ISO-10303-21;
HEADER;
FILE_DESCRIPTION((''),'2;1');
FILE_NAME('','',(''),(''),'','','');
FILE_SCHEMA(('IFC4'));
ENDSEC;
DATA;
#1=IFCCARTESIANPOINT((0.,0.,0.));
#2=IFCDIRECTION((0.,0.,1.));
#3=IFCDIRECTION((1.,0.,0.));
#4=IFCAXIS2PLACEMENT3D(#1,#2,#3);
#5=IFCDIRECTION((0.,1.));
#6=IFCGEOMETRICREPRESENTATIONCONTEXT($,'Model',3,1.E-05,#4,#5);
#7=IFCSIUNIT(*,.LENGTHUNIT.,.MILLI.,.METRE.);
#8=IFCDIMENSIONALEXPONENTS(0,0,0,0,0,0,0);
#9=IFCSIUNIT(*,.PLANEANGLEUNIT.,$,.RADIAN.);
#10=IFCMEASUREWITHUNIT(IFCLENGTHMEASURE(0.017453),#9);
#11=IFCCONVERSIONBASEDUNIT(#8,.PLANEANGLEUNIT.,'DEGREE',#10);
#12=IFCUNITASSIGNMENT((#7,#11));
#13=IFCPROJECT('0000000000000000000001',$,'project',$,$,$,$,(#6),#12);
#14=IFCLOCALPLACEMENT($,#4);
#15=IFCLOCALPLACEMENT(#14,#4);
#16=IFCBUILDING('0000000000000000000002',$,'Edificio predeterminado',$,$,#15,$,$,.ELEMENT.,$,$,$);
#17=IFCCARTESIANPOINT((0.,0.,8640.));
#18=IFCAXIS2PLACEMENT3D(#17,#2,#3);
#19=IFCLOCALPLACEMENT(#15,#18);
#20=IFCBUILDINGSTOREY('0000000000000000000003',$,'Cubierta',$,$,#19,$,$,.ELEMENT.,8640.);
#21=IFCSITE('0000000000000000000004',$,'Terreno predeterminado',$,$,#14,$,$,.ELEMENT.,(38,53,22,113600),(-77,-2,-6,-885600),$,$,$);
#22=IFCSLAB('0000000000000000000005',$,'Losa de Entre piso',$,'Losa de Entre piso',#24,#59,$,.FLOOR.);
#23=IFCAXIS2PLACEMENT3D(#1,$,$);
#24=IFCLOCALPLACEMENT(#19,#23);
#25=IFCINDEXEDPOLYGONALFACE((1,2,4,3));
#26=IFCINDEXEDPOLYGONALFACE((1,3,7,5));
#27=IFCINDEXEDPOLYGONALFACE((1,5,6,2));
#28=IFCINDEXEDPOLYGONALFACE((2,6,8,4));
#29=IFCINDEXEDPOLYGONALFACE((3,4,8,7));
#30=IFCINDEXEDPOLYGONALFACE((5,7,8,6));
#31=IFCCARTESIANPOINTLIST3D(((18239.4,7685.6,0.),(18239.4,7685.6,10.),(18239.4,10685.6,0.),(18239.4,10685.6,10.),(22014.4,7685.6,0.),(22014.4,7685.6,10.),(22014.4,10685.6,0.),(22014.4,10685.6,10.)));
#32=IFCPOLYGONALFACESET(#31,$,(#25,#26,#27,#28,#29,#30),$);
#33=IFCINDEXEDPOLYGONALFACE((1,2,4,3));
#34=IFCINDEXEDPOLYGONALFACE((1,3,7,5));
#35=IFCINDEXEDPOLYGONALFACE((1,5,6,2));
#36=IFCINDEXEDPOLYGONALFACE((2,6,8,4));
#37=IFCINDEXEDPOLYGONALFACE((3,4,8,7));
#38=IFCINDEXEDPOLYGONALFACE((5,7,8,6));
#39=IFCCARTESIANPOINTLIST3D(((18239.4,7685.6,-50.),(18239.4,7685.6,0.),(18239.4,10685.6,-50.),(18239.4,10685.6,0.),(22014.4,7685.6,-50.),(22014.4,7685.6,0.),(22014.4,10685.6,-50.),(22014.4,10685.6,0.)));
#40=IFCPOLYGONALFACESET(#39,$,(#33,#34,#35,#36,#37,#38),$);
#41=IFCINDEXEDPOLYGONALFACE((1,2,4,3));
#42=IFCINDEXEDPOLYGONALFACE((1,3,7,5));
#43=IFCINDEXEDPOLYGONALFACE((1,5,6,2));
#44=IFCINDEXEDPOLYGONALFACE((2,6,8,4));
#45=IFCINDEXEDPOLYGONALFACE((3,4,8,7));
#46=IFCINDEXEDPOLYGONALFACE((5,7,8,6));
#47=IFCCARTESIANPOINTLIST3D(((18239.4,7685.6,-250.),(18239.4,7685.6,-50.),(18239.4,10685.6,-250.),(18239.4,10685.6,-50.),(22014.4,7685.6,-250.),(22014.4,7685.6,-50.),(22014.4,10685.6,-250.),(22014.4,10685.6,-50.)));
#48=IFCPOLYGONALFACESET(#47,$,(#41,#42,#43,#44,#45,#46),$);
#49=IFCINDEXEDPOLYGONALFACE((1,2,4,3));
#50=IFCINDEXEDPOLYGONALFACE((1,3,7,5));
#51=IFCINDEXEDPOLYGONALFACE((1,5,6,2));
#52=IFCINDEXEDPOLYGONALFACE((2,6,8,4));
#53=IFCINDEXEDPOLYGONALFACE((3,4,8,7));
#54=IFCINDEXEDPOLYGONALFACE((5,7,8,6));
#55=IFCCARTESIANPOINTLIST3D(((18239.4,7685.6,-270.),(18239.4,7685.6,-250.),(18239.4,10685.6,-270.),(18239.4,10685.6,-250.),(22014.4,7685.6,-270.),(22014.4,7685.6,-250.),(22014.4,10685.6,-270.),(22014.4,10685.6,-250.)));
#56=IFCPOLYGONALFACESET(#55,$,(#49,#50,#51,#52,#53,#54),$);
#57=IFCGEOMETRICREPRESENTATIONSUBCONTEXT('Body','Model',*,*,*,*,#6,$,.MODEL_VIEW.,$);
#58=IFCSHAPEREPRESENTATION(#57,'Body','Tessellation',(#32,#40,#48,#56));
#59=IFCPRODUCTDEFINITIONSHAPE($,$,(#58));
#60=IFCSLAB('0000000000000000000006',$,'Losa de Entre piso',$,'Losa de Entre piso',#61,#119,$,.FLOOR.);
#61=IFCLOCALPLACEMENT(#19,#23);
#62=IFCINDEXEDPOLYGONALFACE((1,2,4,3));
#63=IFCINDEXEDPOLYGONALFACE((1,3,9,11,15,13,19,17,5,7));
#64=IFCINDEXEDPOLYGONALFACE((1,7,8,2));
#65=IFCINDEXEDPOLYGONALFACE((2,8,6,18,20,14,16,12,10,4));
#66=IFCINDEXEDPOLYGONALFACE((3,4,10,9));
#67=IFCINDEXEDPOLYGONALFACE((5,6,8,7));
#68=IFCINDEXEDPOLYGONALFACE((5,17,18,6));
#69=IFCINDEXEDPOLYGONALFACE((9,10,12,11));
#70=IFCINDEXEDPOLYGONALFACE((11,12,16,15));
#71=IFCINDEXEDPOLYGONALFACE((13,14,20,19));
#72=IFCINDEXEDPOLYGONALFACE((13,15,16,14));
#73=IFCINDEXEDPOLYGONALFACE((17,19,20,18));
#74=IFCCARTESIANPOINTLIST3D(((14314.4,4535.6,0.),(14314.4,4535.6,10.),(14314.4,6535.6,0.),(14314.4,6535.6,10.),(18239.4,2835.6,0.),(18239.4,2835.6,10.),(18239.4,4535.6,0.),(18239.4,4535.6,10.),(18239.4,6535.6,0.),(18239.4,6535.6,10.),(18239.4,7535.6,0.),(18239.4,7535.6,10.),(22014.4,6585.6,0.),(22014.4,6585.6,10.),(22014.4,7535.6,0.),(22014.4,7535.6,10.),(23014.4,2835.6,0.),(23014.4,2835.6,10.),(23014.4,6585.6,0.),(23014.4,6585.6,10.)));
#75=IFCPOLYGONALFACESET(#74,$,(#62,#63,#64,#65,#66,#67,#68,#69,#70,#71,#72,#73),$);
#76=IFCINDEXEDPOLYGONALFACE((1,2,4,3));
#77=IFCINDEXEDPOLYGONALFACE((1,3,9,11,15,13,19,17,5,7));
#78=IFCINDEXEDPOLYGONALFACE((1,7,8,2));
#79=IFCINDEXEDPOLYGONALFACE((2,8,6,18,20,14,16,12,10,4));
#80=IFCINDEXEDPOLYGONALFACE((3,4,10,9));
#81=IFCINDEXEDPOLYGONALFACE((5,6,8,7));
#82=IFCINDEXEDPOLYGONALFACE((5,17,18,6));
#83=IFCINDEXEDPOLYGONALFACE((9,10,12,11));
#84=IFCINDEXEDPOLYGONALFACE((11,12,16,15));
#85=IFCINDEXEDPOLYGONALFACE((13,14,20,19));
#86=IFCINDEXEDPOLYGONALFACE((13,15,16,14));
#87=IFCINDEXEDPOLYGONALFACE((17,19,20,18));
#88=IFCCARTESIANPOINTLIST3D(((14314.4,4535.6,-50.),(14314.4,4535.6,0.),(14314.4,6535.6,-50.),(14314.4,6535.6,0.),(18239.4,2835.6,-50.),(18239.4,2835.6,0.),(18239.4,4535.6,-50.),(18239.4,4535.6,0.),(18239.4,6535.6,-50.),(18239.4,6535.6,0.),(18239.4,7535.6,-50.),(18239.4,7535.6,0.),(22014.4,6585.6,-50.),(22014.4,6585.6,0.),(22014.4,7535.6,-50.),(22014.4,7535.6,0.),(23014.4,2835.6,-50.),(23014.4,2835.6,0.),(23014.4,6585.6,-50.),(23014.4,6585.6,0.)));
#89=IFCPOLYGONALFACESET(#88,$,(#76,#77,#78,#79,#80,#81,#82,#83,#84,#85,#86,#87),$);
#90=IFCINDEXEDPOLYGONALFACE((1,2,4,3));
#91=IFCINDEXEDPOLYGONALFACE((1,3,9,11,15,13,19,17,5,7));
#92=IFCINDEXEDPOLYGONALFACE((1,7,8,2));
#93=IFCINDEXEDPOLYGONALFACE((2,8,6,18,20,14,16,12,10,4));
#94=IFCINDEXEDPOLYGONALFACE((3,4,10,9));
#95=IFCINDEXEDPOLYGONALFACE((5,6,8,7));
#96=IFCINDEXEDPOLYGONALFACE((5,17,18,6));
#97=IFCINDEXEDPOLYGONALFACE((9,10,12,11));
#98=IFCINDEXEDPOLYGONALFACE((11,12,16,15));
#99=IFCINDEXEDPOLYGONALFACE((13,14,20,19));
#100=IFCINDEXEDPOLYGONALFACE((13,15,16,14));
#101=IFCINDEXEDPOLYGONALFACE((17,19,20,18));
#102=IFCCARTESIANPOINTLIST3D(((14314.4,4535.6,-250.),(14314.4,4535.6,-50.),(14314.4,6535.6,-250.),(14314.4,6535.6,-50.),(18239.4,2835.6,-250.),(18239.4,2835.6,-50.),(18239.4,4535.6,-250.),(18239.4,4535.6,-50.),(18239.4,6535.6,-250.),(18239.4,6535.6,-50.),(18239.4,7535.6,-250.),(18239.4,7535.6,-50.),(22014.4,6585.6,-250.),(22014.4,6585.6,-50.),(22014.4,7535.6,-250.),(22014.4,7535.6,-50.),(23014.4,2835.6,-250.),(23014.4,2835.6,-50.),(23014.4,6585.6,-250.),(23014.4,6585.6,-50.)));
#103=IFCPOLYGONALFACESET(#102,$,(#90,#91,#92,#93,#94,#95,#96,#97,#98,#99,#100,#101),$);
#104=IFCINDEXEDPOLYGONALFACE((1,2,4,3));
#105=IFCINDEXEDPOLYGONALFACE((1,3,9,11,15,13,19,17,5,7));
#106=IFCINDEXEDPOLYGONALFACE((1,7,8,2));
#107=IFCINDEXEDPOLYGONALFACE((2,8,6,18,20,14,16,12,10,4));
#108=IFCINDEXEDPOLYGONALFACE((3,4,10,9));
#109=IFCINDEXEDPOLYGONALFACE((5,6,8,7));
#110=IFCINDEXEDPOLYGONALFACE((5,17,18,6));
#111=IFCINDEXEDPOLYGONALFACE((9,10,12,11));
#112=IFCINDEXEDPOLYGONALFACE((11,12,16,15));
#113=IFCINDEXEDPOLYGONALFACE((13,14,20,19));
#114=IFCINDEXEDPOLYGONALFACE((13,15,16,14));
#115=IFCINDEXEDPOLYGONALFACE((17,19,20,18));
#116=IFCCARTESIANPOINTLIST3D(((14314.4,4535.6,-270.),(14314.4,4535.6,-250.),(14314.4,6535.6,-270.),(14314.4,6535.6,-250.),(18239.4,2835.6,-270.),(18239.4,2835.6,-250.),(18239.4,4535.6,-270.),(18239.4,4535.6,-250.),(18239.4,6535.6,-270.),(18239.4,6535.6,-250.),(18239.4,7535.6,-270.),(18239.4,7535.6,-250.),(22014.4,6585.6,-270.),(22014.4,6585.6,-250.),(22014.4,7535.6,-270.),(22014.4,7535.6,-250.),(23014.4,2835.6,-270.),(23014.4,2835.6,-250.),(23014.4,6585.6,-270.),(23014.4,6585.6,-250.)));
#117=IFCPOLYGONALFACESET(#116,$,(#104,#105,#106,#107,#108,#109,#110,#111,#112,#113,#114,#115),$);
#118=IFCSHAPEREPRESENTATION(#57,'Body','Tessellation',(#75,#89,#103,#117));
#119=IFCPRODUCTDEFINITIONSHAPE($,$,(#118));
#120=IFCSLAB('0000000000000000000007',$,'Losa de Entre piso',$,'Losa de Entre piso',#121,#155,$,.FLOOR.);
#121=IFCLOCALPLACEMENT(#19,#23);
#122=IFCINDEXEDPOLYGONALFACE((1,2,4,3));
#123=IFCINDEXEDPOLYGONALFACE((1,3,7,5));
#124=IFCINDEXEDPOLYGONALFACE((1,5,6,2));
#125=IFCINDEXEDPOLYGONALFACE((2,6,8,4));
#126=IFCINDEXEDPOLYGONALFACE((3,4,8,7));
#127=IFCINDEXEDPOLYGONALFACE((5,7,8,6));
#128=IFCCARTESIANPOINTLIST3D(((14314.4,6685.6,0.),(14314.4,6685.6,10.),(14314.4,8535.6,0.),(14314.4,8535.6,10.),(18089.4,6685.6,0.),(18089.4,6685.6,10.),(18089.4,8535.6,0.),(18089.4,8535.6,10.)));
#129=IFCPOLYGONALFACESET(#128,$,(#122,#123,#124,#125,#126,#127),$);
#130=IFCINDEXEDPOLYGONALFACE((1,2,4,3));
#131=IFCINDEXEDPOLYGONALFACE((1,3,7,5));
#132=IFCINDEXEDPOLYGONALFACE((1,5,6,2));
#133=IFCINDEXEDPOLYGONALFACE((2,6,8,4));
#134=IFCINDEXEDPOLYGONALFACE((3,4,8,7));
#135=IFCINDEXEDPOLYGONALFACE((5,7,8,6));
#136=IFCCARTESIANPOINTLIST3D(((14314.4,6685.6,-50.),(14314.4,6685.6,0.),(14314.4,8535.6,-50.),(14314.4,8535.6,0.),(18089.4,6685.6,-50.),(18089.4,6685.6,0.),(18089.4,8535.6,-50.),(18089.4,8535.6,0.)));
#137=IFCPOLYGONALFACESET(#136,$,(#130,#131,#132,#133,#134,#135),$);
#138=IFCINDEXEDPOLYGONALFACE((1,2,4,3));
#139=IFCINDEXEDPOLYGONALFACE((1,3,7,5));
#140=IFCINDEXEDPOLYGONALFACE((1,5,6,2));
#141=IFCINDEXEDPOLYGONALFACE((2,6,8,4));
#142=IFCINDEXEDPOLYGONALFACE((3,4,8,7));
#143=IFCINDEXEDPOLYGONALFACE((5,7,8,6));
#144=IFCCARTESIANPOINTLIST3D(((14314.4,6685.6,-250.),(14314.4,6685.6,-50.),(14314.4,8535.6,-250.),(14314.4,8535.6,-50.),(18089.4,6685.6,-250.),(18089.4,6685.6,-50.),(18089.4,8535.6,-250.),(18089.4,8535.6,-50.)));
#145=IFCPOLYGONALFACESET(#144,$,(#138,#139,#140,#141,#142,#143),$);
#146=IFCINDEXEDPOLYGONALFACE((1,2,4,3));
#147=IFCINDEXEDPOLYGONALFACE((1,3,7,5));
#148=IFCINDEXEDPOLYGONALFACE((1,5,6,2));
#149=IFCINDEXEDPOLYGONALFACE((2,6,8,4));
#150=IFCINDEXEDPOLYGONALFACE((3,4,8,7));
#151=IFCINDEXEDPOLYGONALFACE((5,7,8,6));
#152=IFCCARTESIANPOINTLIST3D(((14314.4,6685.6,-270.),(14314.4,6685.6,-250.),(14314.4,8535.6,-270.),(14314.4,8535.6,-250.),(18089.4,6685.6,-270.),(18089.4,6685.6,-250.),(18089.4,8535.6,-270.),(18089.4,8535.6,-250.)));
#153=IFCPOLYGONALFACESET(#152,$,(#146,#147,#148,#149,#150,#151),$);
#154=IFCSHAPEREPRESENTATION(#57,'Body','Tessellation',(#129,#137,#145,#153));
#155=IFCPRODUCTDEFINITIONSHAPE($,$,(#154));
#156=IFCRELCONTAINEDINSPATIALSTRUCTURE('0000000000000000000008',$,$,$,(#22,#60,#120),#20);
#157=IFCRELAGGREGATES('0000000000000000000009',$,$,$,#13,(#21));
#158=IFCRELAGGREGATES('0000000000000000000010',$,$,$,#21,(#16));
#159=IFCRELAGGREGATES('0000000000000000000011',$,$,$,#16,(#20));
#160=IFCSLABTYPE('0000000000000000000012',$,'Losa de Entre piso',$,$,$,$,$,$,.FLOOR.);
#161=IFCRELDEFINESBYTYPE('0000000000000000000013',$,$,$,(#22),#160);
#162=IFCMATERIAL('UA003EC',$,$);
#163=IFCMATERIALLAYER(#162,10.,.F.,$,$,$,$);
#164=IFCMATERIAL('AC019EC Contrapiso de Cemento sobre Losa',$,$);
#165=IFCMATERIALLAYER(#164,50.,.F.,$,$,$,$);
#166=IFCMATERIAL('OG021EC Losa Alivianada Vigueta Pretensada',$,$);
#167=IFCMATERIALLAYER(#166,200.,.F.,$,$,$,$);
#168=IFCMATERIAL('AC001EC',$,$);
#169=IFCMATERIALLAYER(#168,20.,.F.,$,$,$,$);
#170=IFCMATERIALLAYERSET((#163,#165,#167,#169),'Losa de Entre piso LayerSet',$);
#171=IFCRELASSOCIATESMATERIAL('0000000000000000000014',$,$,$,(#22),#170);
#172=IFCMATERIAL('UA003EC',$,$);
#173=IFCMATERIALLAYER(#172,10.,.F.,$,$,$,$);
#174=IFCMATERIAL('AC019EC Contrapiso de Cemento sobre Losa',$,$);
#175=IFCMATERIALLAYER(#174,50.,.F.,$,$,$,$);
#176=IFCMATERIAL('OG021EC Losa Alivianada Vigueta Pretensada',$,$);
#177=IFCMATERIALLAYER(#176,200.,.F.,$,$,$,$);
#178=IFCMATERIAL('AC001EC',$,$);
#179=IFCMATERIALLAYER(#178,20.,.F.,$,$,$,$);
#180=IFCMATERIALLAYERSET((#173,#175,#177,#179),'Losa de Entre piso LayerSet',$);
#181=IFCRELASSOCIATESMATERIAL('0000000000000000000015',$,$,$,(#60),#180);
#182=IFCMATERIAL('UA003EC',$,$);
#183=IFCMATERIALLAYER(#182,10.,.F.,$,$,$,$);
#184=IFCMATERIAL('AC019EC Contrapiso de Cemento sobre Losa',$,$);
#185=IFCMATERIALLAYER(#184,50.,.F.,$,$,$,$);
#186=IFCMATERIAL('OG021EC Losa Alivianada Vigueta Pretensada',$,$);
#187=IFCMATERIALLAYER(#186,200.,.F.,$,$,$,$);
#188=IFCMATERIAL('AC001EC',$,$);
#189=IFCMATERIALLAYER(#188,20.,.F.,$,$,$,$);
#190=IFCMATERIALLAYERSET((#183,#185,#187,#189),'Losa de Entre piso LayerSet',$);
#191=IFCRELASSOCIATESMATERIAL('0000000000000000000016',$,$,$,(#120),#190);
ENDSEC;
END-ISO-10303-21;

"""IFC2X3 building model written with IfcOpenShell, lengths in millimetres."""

from ifc_helpers import new_model, entity, si_unit, converted_unit, direction, frame, origin_with_axes, place, context, subcontext, project, spatial, polyline, outline, extrude, material, layer, layer_set, layer_usage, type_object, element, save


model = new_model("IFC2X3")

# Units and contexts
model_context = context("Model", 3, precision=1e-05, world=origin_with_axes(), true_north=direction((0.0, 1.0)))
body_context = subcontext(model_context, "Body", "Model", "MODEL_VIEW")
ifc_project = project(units=[si_unit("LENGTHUNIT", "METRE", prefix="MILLI"), converted_unit("PLANEANGLEUNIT", "DEGREE", entity("IfcLengthMeasure", 0.017453), si_unit("PLANEANGLEUNIT", "RADIAN"), dimensions=[0, 0, 0, 0, 0, 0, 0])], contexts=[model_context])

# Site, building, storey
site_placement = place(None, origin_with_axes())
site = spatial("IfcSite", under=ifc_project, at=site_placement, Name="Terreno predeterminado", CompositionType="ELEMENT", RefLatitude=(38, 53, 22, 113600), RefLongitude=(-77, -2, -6, -885600))
building_placement = place(site_placement, origin_with_axes())
building = spatial("IfcBuilding", under=site, at=building_placement, Name="Edificio predeterminado", CompositionType="ELEMENT")
storey_placement = place(building_placement, frame((0.0, 0.0, 8640.0), z_axis=(0.0, 0.0, 1.0), x_axis=(1.0, 0.0, 0.0)))
storey = spatial("IfcBuildingStorey", under=building, at=storey_placement, Name="Cubierta", CompositionType="ELEMENT", Elevation=8640.0)

# Slabs
ifc_material_1 = material(Name="UA003EC")
ifc_layer_1 = layer(ifc_material_1, 10.0, ventilated=False)
ifc_material_2 = material(Name="AC019EC Contrapiso de Cemento sobre Losa")
ifc_layer_2 = layer(ifc_material_2, 50.0, ventilated=False)
ifc_material_3 = material(Name="OG021EC Losa Alivianada Vigueta Pretensada")
ifc_layer_3 = layer(ifc_material_3, 200.0, ventilated=False)
ifc_material_4 = material(Name="AC001EC")
ifc_layer_4 = layer(ifc_material_4, 20.0, ventilated=False)
ifc_layer_set_1 = layer_set([ifc_layer_1, ifc_layer_2, ifc_layer_3, ifc_layer_4], Name="Losa de Entre piso LayerSet")
ifc_layer_usage_1 = layer_usage(ifc_layer_set_1, "AXIS3", "NEGATIVE", 0.0)
slab_type = type_object("IfcSlabType", Name="Losa de Entre piso", PredefinedType="FLOOR")
slab_1_placement = place(storey_placement, frame((0.0, 0.0, -8640.0), z_axis=(0.0, 0.0, 1.0), x_axis=(1.0, 0.0, 0.0)))
element("IfcSlab", 1, at=slab_1_placement, inside=storey, type_object=slab_type, material=ifc_layer_usage_1, Name="Losa de Entre piso", ObjectType="Losa de Entre piso", PredefinedType="FLOOR", context=body_context, shape_type="SweptSolid", body=[
    extrude(outline(polyline([(0.0, 3000.0), (3775.0, 3000.0), (3775.0, 0.0), (0.0, 0.0), (0.0, 3000.0)])), frame((22014.4, 7685.6, 8640.0), z_axis=(0.0, 0.0, -1.0), x_axis=(-1.0, 0.0, 0.0)), (0.0, 0.0, -1.0), 10.0),
    extrude(outline(polyline([(0.0, 3000.0), (3775.0, 3000.0), (3775.0, 0.0), (0.0, 0.0), (0.0, 3000.0)])), frame((22014.4, 7685.6, 8590.0), z_axis=(0.0, 0.0, -1.0), x_axis=(-1.0, 0.0, 0.0)), (0.0, 0.0, -1.0), 50.0),
    extrude(outline(polyline([(0.0, 3000.0), (3775.0, 3000.0), (3775.0, 0.0), (0.0, 0.0), (0.0, 3000.0)])), frame((22014.4, 7685.6, 8390.0), z_axis=(0.0, 0.0, -1.0), x_axis=(-1.0, 0.0, 0.0)), (0.0, 0.0, -1.0), 200.0),
    extrude(outline(polyline([(0.0, 3000.0), (3775.0, 3000.0), (3775.0, 0.0), (0.0, 0.0), (0.0, 3000.0)])), frame((22014.4, 7685.6, 8370.0), z_axis=(0.0, 0.0, -1.0), x_axis=(-1.0, 0.0, 0.0)), (0.0, 0.0, -1.0), 20.0),
])
ifc_material_5 = material(Name="UA003EC")
ifc_layer_5 = layer(ifc_material_5, 10.0, ventilated=False)
ifc_material_6 = material(Name="AC019EC Contrapiso de Cemento sobre Losa")
ifc_layer_6 = layer(ifc_material_6, 50.0, ventilated=False)
ifc_material_7 = material(Name="OG021EC Losa Alivianada Vigueta Pretensada")
ifc_layer_7 = layer(ifc_material_7, 200.0, ventilated=False)
ifc_material_8 = material(Name="AC001EC")
ifc_layer_8 = layer(ifc_material_8, 20.0, ventilated=False)
ifc_layer_set_2 = layer_set([ifc_layer_5, ifc_layer_6, ifc_layer_7, ifc_layer_8], Name="Losa de Entre piso LayerSet")
ifc_layer_usage_2 = layer_usage(ifc_layer_set_2, "AXIS3", "NEGATIVE", 0.0)
slab_2_placement = place(storey_placement, frame((0.0, 0.0, -8640.0), z_axis=(0.0, 0.0, 1.0), x_axis=(1.0, 0.0, 0.0)))
element("IfcSlab", 2, at=slab_2_placement, inside=storey, material=ifc_layer_usage_2, Name="Losa de Entre piso", ObjectType="Losa de Entre piso", PredefinedType="FLOOR", context=body_context, shape_type="SweptSolid", body=[
    extrude(outline(polyline([(0.0, 1000.0), (-3925.0, 1000.0), (-3925.0, 3000.0), (0.0, 3000.0), (0.0, 4700.0), (4775.0, 4700.0), (4775.0, 950.0), (3775.0, 950.0), (3775.0, 0.0), (0.0, 0.0), (0.0, 1000.0)])), frame((18239.4, 7535.6, 8640.0), z_axis=(0.0, 0.0, -1.0), x_axis=(1.0, 0.0, 0.0)), (0.0, 0.0, -1.0), 10.0),
    extrude(outline(polyline([(0.0, 1000.0), (-3925.0, 1000.0), (-3925.0, 3000.0), (0.0, 3000.0), (0.0, 4700.0), (4775.0, 4700.0), (4775.0, 950.0), (3775.0, 950.0), (3775.0, 0.0), (0.0, 0.0), (0.0, 1000.0)])), frame((18239.4, 7535.6, 8590.0), z_axis=(0.0, 0.0, -1.0), x_axis=(1.0, 0.0, 0.0)), (0.0, 0.0, -1.0), 50.0),
    extrude(outline(polyline([(0.0, 1000.0), (-3925.0, 1000.0), (-3925.0, 3000.0), (0.0, 3000.0), (0.0, 4700.0), (4775.0, 4700.0), (4775.0, 950.0), (3775.0, 950.0), (3775.0, 0.0), (0.0, 0.0), (0.0, 1000.0)])), frame((18239.4, 7535.6, 8390.0), z_axis=(0.0, 0.0, -1.0), x_axis=(1.0, 0.0, 0.0)), (0.0, 0.0, -1.0), 200.0),
    extrude(outline(polyline([(0.0, 1000.0), (-3925.0, 1000.0), (-3925.0, 3000.0), (0.0, 3000.0), (0.0, 4700.0), (4775.0, 4700.0), (4775.0, 950.0), (3775.0, 950.0), (3775.0, 0.0), (0.0, 0.0), (0.0, 1000.0)])), frame((18239.4, 7535.6, 8370.0), z_axis=(0.0, 0.0, -1.0), x_axis=(1.0, 0.0, 0.0)), (0.0, 0.0, -1.0), 20.0),
])
ifc_material_9 = material(Name="UA003EC")
ifc_layer_9 = layer(ifc_material_9, 10.0, ventilated=False)
ifc_material_10 = material(Name="AC019EC Contrapiso de Cemento sobre Losa")
ifc_layer_10 = layer(ifc_material_10, 50.0, ventilated=False)
ifc_material_11 = material(Name="OG021EC Losa Alivianada Vigueta Pretensada")
ifc_layer_11 = layer(ifc_material_11, 200.0, ventilated=False)
ifc_material_12 = material(Name="AC001EC")
ifc_layer_12 = layer(ifc_material_12, 20.0, ventilated=False)
ifc_layer_set_3 = layer_set([ifc_layer_9, ifc_layer_10, ifc_layer_11, ifc_layer_12], Name="Losa de Entre piso LayerSet")
ifc_layer_usage_3 = layer_usage(ifc_layer_set_3, "AXIS3", "NEGATIVE", 0.0)
slab_3_placement = place(storey_placement, frame((0.0, 0.0, -8640.0), z_axis=(0.0, 0.0, 1.0), x_axis=(1.0, 0.0, 0.0)))
element("IfcSlab", 3, at=slab_3_placement, inside=storey, material=ifc_layer_usage_3, Name="Losa de Entre piso", ObjectType="Losa de Entre piso", PredefinedType="FLOOR", context=body_context, shape_type="SweptSolid", body=[
    extrude(outline(polyline([(0.0, 1850.0), (3775.0, 1850.0), (3775.0, 0.0), (0.0, 0.0), (0.0, 1850.0)])), frame((18089.4, 6685.6, 8640.0), z_axis=(0.0, 0.0, -1.0), x_axis=(-1.0, 0.0, 0.0)), (0.0, 0.0, -1.0), 10.0),
    extrude(outline(polyline([(0.0, 1850.0), (3775.0, 1850.0), (3775.0, 0.0), (0.0, 0.0), (0.0, 1850.0)])), frame((18089.4, 6685.6, 8590.0), z_axis=(0.0, 0.0, -1.0), x_axis=(-1.0, 0.0, 0.0)), (0.0, 0.0, -1.0), 50.0),
    extrude(outline(polyline([(0.0, 1850.0), (3775.0, 1850.0), (3775.0, 0.0), (0.0, 0.0), (0.0, 1850.0)])), frame((18089.4, 6685.6, 8390.0), z_axis=(0.0, 0.0, -1.0), x_axis=(-1.0, 0.0, 0.0)), (0.0, 0.0, -1.0), 200.0),
    extrude(outline(polyline([(0.0, 1850.0), (3775.0, 1850.0), (3775.0, 0.0), (0.0, 0.0), (0.0, 1850.0)])), frame((18089.4, 6685.6, 8370.0), z_axis=(0.0, 0.0, -1.0), x_axis=(-1.0, 0.0, 0.0)), (0.0, 0.0, -1.0), 20.0),
])

save(model, "model.ifc")
